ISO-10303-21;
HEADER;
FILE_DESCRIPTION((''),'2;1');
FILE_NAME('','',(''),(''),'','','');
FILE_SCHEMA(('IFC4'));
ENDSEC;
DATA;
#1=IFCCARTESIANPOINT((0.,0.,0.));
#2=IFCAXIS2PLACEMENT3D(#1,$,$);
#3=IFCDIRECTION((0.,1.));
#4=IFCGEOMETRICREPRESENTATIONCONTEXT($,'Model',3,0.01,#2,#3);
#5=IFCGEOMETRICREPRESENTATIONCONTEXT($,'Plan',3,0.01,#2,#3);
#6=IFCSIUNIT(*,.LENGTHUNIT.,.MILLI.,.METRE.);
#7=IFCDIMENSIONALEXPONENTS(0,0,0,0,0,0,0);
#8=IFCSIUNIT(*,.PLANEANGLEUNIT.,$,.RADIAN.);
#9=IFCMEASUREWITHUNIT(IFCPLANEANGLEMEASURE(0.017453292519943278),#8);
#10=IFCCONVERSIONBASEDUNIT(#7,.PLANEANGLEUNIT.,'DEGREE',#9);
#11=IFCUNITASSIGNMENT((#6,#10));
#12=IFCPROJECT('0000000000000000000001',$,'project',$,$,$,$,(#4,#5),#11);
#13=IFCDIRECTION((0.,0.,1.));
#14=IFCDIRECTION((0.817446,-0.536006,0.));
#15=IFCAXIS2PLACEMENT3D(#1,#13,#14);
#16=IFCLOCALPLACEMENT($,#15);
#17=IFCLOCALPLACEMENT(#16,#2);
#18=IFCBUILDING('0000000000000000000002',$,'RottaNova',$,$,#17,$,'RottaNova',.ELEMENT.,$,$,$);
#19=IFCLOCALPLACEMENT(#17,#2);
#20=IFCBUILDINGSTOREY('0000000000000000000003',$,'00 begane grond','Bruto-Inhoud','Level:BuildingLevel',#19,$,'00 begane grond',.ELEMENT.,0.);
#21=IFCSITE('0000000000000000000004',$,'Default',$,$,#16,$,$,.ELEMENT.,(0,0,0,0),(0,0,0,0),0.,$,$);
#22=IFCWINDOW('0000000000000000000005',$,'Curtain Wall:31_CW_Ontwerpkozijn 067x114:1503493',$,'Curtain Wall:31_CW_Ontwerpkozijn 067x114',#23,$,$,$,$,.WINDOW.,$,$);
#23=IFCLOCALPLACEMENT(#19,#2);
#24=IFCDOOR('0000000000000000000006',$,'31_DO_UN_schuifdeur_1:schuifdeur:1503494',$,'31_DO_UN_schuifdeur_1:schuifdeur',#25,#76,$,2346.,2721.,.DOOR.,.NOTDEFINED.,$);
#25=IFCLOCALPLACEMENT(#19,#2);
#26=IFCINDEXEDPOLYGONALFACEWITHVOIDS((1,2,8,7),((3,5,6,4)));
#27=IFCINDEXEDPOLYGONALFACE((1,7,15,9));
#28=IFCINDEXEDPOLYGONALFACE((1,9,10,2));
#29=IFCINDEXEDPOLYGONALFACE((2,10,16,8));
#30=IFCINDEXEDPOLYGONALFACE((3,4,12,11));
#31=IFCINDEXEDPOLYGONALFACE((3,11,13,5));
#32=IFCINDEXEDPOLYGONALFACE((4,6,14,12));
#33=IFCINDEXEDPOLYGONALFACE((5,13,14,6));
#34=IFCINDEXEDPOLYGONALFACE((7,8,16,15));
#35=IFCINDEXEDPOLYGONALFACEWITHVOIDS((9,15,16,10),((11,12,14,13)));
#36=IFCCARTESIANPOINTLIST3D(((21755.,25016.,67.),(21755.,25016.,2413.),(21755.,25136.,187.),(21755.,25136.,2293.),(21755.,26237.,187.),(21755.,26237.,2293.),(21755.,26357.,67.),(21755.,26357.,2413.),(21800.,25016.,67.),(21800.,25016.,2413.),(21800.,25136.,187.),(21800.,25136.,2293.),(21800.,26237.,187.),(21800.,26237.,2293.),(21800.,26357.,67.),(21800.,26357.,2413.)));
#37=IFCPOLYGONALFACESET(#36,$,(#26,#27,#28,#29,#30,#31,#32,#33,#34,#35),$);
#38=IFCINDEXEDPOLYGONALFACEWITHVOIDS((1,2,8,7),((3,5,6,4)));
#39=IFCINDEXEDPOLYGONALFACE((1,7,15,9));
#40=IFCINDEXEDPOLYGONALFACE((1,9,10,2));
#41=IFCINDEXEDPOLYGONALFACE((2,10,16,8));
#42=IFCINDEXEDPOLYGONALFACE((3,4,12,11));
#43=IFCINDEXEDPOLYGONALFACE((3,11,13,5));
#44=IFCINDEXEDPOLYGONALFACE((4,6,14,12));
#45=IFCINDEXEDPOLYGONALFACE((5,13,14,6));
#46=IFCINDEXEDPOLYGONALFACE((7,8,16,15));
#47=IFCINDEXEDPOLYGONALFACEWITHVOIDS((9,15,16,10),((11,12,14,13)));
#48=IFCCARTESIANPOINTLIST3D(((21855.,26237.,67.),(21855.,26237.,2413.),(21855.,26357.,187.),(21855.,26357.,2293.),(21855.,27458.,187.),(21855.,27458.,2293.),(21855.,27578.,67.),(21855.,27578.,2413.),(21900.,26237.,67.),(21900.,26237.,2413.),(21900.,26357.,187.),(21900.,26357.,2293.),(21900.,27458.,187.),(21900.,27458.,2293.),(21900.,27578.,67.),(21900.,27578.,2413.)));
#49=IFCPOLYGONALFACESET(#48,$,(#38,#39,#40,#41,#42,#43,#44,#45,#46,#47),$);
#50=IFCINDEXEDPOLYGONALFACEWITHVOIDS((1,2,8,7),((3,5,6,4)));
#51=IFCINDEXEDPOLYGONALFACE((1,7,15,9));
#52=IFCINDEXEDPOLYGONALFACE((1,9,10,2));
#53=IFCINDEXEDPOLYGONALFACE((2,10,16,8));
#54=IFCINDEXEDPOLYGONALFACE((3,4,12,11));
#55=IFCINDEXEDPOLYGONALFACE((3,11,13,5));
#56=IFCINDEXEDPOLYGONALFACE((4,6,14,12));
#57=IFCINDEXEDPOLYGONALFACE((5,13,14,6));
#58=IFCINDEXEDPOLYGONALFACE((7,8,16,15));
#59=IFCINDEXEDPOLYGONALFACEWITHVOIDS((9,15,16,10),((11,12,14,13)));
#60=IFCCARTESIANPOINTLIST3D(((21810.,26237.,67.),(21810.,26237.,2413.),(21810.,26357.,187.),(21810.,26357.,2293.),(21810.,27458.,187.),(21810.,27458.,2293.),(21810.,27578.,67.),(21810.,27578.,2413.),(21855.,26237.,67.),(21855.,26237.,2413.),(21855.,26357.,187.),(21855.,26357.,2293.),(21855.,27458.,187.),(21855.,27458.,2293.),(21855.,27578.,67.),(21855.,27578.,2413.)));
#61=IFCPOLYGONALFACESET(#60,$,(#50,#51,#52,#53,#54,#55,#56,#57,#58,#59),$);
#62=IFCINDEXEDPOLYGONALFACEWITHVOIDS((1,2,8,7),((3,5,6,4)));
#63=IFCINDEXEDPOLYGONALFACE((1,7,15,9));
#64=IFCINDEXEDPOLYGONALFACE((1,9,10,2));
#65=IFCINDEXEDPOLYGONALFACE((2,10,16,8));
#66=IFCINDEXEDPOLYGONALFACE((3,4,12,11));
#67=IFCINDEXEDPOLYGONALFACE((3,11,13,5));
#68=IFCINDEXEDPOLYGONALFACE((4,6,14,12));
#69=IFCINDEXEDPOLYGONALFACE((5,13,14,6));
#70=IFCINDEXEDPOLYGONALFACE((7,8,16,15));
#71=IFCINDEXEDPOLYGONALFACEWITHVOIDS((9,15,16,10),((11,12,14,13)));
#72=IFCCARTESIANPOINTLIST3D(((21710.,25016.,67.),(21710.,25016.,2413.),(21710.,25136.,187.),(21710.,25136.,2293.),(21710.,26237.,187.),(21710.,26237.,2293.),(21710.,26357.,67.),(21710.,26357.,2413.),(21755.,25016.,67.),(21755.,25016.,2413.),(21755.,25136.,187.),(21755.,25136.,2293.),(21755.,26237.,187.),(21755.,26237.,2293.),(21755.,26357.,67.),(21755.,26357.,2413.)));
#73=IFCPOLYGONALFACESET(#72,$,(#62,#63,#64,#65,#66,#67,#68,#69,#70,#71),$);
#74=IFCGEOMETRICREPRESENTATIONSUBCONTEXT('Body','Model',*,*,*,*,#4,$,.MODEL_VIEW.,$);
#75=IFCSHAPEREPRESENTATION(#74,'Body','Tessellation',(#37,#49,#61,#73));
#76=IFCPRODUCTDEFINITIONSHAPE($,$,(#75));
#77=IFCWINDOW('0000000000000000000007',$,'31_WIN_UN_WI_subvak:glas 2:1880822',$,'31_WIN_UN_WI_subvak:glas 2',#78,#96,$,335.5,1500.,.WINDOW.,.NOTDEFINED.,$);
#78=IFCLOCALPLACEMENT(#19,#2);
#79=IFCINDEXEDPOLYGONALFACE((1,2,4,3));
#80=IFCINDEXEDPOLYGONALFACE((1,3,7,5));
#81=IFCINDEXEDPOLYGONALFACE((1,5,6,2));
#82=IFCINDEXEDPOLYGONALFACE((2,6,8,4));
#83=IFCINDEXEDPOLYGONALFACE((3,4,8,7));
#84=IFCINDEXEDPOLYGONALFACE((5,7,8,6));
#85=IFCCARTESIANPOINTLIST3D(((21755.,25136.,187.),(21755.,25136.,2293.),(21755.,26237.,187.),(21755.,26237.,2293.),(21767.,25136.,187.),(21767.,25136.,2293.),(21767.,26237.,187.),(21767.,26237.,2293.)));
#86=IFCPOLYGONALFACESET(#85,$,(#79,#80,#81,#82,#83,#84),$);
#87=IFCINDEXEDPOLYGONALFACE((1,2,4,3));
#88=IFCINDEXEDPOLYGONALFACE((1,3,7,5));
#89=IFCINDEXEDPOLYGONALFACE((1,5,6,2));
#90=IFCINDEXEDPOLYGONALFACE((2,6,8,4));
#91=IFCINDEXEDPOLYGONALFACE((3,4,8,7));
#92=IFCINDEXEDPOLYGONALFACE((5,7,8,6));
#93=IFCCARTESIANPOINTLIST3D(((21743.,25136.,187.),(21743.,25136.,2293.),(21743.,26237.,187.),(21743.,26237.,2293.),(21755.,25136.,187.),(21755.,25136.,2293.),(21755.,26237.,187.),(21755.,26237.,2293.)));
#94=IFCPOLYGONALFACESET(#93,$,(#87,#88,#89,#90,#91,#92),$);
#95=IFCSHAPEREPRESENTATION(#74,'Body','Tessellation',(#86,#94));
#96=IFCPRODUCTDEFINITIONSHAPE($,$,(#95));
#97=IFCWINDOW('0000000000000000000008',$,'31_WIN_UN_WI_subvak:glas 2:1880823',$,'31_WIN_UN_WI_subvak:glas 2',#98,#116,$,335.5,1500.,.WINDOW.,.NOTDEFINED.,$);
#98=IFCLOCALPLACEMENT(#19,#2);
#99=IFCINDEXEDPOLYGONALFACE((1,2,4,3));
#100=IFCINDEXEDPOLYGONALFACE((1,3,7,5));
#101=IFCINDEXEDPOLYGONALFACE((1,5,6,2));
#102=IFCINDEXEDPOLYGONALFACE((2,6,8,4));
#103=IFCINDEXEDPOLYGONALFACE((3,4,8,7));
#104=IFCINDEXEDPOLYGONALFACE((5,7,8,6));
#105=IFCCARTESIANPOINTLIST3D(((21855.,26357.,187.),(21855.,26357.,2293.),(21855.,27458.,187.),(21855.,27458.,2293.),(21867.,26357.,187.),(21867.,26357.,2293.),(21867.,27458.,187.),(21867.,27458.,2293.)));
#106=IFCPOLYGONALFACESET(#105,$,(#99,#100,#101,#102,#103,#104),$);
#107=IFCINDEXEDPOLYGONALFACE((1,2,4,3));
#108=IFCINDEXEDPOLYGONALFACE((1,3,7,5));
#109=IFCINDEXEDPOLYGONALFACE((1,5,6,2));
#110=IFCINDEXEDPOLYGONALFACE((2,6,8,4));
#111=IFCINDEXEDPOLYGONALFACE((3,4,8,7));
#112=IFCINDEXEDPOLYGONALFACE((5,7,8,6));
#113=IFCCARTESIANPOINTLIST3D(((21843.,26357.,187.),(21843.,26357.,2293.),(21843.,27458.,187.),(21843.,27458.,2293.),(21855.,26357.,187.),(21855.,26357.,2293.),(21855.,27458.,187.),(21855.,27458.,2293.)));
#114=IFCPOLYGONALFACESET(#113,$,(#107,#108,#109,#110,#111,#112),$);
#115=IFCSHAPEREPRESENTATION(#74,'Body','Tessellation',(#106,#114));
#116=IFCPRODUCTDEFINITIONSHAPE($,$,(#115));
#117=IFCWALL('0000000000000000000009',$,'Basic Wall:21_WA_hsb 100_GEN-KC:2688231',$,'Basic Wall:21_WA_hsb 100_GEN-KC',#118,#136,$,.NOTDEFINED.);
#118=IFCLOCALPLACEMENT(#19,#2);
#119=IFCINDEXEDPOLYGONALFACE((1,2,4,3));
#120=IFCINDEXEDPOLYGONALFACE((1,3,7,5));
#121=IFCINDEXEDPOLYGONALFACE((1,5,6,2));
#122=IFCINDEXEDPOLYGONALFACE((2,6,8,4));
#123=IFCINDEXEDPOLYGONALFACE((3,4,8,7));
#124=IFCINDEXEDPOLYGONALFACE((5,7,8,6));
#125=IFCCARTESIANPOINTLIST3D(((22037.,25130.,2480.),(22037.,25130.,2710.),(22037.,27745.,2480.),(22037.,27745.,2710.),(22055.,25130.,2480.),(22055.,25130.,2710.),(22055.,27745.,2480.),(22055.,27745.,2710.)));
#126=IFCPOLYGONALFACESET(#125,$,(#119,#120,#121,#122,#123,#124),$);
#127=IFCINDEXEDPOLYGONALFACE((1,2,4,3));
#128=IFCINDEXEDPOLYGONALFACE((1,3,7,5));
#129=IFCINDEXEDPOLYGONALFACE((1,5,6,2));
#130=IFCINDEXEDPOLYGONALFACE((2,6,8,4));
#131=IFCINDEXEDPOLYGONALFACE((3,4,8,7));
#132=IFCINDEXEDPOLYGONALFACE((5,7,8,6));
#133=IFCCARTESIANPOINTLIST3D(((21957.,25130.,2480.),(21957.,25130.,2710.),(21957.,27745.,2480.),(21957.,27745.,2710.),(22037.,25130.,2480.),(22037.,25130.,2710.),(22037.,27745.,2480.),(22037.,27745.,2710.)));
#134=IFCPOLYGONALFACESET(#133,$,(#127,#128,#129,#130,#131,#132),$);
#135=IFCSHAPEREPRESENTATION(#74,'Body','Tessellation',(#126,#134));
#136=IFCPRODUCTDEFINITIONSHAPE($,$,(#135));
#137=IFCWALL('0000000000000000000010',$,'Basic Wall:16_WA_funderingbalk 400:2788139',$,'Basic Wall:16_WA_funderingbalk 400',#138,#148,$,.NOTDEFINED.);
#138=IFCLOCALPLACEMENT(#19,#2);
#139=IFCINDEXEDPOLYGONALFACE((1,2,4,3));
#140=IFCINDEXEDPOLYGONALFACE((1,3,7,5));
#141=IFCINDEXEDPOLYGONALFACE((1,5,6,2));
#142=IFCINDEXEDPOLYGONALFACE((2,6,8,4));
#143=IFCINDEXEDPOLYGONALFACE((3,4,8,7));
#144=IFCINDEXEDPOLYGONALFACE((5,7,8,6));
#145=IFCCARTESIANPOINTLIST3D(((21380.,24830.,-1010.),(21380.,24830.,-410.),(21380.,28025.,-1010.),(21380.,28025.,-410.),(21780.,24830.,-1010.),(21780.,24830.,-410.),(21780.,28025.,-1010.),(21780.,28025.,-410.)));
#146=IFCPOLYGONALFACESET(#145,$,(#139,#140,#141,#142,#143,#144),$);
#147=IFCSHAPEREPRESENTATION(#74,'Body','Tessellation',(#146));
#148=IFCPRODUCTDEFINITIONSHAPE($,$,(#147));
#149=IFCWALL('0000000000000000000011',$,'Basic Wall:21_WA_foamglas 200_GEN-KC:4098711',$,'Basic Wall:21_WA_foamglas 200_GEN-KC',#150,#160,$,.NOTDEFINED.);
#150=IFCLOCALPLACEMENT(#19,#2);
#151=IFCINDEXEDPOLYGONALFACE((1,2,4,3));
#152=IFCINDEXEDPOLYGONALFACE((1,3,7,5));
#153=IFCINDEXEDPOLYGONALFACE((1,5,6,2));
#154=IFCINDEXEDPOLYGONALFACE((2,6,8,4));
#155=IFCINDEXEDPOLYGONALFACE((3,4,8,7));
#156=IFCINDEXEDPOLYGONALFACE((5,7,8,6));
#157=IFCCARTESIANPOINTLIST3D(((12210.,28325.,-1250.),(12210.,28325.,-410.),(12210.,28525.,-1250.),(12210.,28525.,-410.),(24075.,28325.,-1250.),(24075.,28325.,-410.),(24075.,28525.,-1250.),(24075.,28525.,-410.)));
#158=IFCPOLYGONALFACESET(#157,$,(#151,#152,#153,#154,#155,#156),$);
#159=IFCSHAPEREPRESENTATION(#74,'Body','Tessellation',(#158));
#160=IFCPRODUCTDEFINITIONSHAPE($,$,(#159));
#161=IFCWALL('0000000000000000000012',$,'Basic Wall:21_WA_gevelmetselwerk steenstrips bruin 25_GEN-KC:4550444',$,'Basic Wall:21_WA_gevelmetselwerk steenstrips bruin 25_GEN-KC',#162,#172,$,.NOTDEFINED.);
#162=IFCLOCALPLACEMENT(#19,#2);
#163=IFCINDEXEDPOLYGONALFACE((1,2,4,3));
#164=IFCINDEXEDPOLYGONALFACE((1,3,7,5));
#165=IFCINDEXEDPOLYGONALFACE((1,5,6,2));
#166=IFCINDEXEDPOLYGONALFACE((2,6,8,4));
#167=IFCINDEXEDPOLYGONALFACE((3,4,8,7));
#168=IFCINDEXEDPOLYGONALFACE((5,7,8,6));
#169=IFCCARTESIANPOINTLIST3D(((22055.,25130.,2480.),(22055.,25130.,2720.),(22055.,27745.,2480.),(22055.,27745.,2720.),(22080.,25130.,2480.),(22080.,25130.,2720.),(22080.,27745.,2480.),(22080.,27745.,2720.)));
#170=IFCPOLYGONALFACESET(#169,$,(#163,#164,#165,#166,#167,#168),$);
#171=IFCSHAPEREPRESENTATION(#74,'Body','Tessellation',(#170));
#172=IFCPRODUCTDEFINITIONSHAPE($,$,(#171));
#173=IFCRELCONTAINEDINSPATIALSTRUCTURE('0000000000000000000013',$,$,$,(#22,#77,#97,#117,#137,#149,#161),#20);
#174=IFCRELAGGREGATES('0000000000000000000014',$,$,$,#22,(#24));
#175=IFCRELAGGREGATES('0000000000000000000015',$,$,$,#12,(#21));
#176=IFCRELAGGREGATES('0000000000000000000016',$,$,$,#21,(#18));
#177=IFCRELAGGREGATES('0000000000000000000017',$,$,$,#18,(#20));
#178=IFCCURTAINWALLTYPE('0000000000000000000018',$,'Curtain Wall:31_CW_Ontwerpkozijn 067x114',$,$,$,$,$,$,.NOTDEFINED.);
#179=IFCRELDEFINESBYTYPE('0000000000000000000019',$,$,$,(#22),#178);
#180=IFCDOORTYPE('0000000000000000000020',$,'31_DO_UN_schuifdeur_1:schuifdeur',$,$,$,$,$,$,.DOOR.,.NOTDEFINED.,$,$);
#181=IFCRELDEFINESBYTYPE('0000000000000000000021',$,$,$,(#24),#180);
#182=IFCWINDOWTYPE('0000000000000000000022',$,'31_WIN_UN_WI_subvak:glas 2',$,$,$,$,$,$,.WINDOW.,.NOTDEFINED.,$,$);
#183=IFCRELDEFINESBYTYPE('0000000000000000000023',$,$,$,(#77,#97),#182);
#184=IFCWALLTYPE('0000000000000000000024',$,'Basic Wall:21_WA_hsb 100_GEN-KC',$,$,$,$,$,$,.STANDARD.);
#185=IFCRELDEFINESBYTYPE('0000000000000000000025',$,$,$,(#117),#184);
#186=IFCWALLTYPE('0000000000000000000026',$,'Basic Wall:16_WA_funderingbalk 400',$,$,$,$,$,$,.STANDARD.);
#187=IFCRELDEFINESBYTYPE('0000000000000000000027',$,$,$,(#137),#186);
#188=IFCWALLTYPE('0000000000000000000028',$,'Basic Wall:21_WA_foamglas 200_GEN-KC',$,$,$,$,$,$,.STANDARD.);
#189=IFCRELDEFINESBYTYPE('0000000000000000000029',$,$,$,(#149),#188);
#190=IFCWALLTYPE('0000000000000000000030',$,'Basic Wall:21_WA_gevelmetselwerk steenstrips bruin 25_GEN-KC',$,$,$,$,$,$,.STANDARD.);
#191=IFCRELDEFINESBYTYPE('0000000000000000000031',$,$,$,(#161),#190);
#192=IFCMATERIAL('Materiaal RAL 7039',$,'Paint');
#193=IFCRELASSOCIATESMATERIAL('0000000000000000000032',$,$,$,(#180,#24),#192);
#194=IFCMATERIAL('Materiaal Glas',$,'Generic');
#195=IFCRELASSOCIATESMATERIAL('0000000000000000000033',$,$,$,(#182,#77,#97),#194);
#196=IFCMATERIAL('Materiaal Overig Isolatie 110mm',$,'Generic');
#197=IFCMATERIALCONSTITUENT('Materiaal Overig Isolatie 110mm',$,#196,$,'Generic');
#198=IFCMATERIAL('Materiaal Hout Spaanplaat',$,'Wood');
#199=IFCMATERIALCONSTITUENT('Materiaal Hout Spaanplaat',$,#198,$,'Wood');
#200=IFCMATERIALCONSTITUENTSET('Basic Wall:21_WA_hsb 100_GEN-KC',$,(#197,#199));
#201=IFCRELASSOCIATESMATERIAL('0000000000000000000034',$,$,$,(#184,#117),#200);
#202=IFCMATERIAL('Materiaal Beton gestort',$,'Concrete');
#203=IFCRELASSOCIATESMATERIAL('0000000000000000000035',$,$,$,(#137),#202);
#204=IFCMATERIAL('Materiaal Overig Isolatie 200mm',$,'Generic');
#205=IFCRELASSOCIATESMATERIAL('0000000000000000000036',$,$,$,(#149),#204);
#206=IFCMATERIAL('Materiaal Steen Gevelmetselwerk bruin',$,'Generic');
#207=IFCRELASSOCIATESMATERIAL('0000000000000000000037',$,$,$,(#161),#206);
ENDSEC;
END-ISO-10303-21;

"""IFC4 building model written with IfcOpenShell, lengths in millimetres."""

from ifc_helpers import new_model, entity, si_unit, converted_unit, direction, frame, origin, place, context, subcontext, project, spatial, indexed_curve, outline, extrude, source, transform, mapped, material, constituent, constituent_set, type_object, type_shapes, element, aggregate, save


model = new_model("IFC4")

# Units and contexts
model_context = context("Model", 3, precision=0.01, world=origin(), true_north=direction((0.0, 1.0)))
plan_context = context("Plan", 3, precision=0.01, world=origin(), true_north=direction((0.0, 1.0)))
body_context = subcontext(model_context, "Body", "Model", "MODEL_VIEW")
ifc_project = project(units=[si_unit("LENGTHUNIT", "METRE", prefix="MILLI"), converted_unit("PLANEANGLEUNIT", "DEGREE", entity("IfcPlaneAngleMeasure", 0.017453292519943278), si_unit("PLANEANGLEUNIT", "RADIAN"), dimensions=[0, 0, 0, 0, 0, 0, 0])], contexts=[model_context, plan_context])

# Site, building, storey
site_placement = place(None, frame((0.0, 0.0, 0.0), z_axis=(0.0, 0.0, 1.0), x_axis=(0.817446, -0.536006, 0.0)))
site = spatial("IfcSite", under=ifc_project, at=site_placement, Name="Default", CompositionType="ELEMENT", RefLatitude=(0, 0, 0, 0), RefLongitude=(0, 0, 0, 0), RefElevation=0.0)
building_placement = place(site_placement, origin())
building = spatial("IfcBuilding", under=site, at=building_placement, Name="RottaNova", LongName="RottaNova", CompositionType="ELEMENT")
storey_placement = place(building_placement, origin())
storey = spatial("IfcBuildingStorey", under=building, at=storey_placement, Name="00 begane grond", Description="Bruto-Inhoud", ObjectType="Level:BuildingLevel", LongName="00 begane grond", CompositionType="ELEMENT", Elevation=0.0)

# Window
curtain_wall_type = type_object("IfcCurtainWallType", Name="Curtain Wall:31_CW_Ontwerpkozijn 067x114", PredefinedType="NOTDEFINED")
window_1_placement = place(storey_placement, origin())
window_1 = element("IfcWindow", 1, at=window_1_placement, inside=storey, type_object=curtain_wall_type, Name="Curtain Wall:31_CW_Ontwerpkozijn 067x114:1503493", ObjectType="Curtain Wall:31_CW_Ontwerpkozijn 067x114", PredefinedType="WINDOW")
ifc_material_1 = material(Name="Materiaal RAL 7039", Category="Paint")

# Shared definitions
ifc_material_2 = material(Name="Materiaal Glas", Category="Generic")

# Shared definitions
ifc_material_3 = material(Name="Materiaal Steen Gevelmetselwerk bruin", Category="Generic")

# Door
door_type = type_object("IfcDoorType", Name="31_DO_UN_schuifdeur_1:schuifdeur", OperationType="NOTDEFINED", PredefinedType="DOOR", material=ifc_material_1)
shared_shape_1 = source(origin(), body_context, "Body", "SweptSolid", [
    extrude(outline(indexed_curve([(-670.5, -1173.0), (670.5, -1173.0), (670.5, 1173.0), (-670.5, 1173.0), (-670.5, -1173.0)], self_intersect=False), holes=[indexed_curve([(-550.5, -1053.0), (-550.5, 1053.0), (550.5, 1053.0), (550.5, -1053.0), (-550.5, -1053.0)], self_intersect=False)]), frame((610.5, 45.0, 1173.0), z_axis=(0.0, 1.0, 0.0), x_axis=(1.0, 0.0, 0.0)), (0.0, 0.0, 1.0), 45.0),
    extrude(outline(indexed_curve([(-670.5, -1173.0), (670.5, -1173.0), (670.5, 1173.0), (-670.5, 1173.0), (-670.5, -1173.0)], self_intersect=False), holes=[indexed_curve([(-550.5, -1053.0), (-550.5, 1053.0), (550.5, 1053.0), (550.5, -1053.0), (-550.5, -1053.0)], self_intersect=False)]), frame((-610.5, 145.0, 1173.0), z_axis=(0.0, 1.0, 0.0), x_axis=(1.0, 0.0, 0.0)), (0.0, 0.0, 1.0), 45.0),
    extrude(outline(indexed_curve([(-670.5, -1173.0), (670.5, -1173.0), (670.5, 1173.0), (-670.5, 1173.0), (-670.5, -1173.0)], self_intersect=False), holes=[indexed_curve([(-550.5, -1053.0), (-550.5, 1053.0), (550.5, 1053.0), (550.5, -1053.0), (-550.5, -1053.0)], self_intersect=False)]), frame((-610.5, 100.0, 1173.0), z_axis=(0.0, 1.0, 0.0), x_axis=(1.0, 0.0, 0.0)), (0.0, 0.0, 1.0), 45.0),
    extrude(outline(indexed_curve([(-670.5, -1173.0), (670.5, -1173.0), (670.5, 1173.0), (-670.5, 1173.0), (-670.5, -1173.0)], self_intersect=False), holes=[indexed_curve([(-550.5, -1053.0), (-550.5, 1053.0), (550.5, 1053.0), (550.5, -1053.0), (-550.5, -1053.0)], self_intersect=False)]), frame((610.5, 0.0, 1173.0), z_axis=(0.0, 1.0, 0.0), x_axis=(1.0, 0.0, 0.0)), (0.0, 0.0, 1.0), 45.0),
])
type_shapes(door_type, [shared_shape_1])
door_placement = place(window_1_placement, frame((21710.0, 26297.0, 67.0), z_axis=(0.0, 0.0, 1.0), x_axis=(0.0, -1.0, 0.0)))
door = element("IfcDoor", 2, at=door_placement, type_object=door_type, material=ifc_material_1, Name="31_DO_UN_schuifdeur_1:schuifdeur:1503494", ObjectType="31_DO_UN_schuifdeur_1:schuifdeur", OperationType="NOTDEFINED", OverallHeight=2346.0, OverallWidth=2721.0, PredefinedType="DOOR", context=body_context, shape_type="MappedRepresentation", body=[
    mapped(shared_shape_1, transform((0.0, 0.0, 0.0), scale=1.0)),
])
aggregate(window_1, [door])

# Windows
window_type = type_object("IfcWindowType", Name="31_WIN_UN_WI_subvak:glas 2", PartitioningType="NOTDEFINED", PredefinedType="WINDOW", material=ifc_material_2)
shared_shape_2 = source(origin(), body_context, "Body", "SweptSolid", [
    extrude(outline(indexed_curve([(-6.0, -550.5), (6.0, -550.5), (6.0, 550.5), (-6.0, 550.5), (-6.0, -550.5)], self_intersect=False)), frame((0.0, 6.0, 0.0), z_axis=(0.0, 0.0, 1.0), x_axis=(0.0, -1.0, 0.0)), (0.0, 0.0, 1.0), 2106.0),
    extrude(outline(indexed_curve([(-6.0, -550.5), (6.0, -550.5), (6.0, 550.5), (-6.0, 550.5), (-6.0, -550.5)], self_intersect=False)), frame((0.0, -6.0, 0.0), z_axis=(0.0, 0.0, 1.0), x_axis=(0.0, -1.0, 0.0)), (0.0, 0.0, 1.0), 2106.0),
])
type_shapes(window_type, [shared_shape_2])
for number, where, z_axis, x_axis, name in (
    (3, (21755.0, 25686.5, 187.0), (0.0, 0.0, 1.0), (0.0, -1.0, 0.0), "31_WIN_UN_WI_subvak:glas 2:1880822"),
    (4, (21855.0, 26907.5, 187.0), (0.0, 0.0, 1.0), (0.0, -1.0, 0.0), "31_WIN_UN_WI_subvak:glas 2:1880823"),
):
    element("IfcWindow", number, at=place(storey_placement, frame(where, z_axis=z_axis, x_axis=x_axis)), inside=storey, type_object=window_type, material=ifc_material_2, Name=name, ObjectType="31_WIN_UN_WI_subvak:glas 2", OverallHeight=335.5, OverallWidth=1500.0, PartitioningType="NOTDEFINED", PredefinedType="WINDOW", context=body_context, shape_type="MappedRepresentation", body=[
        mapped(shared_shape_2, transform((0.0, 0.0, 0.0), scale=1.0)),
    ])

# Walls
ifc_material_4 = material(Name="Materiaal Overig Isolatie 110mm", Category="Generic")
ifc_constituent_1 = constituent(ifc_material_4, Name="Materiaal Overig Isolatie 110mm", Category="Generic")
ifc_material_5 = material(Name="Materiaal Hout Spaanplaat", Category="Wood")
ifc_constituent_2 = constituent(ifc_material_5, Name="Materiaal Hout Spaanplaat", Category="Wood")
ifc_constituent_set = constituent_set(constituents=[ifc_constituent_1, ifc_constituent_2], Name="Basic Wall:21_WA_hsb 100_GEN-KC")
wall_type_1 = type_object("IfcWallType", Name="Basic Wall:21_WA_hsb 100_GEN-KC", PredefinedType="STANDARD", material=ifc_constituent_set)
wall_1_placement = place(storey_placement, frame((22006.0, 25130.0, 2480.0), z_axis=(0.0, 0.0, 1.0), x_axis=(0.0, 1.0, 0.0)))
element("IfcWall", 5, at=wall_1_placement, inside=storey, type_object=wall_type_1, material=ifc_constituent_set, Name="Basic Wall:21_WA_hsb 100_GEN-KC:2688231", ObjectType="Basic Wall:21_WA_hsb 100_GEN-KC", PredefinedType="NOTDEFINED", context=body_context, shape_type="SweptSolid", body=[
    extrude(outline(indexed_curve([(-9.0, -1307.5), (9.0, -1307.5), (9.0, 1307.5), (-9.0, 1307.5), (-9.0, -1307.5)], self_intersect=False)), frame((1307.5, -40.0, 0.0), z_axis=(0.0, 0.0, 1.0), x_axis=(0.0, 1.0, 0.0)), (0.0, 0.0, 1.0), 230.0),
    extrude(outline(indexed_curve([(-40.0, -1307.5), (40.0, -1307.5), (40.0, 1307.5), (-40.0, 1307.5), (-40.0, -1307.5)], self_intersect=False)), frame((1307.5, 9.0, 0.0), z_axis=(0.0, 0.0, 1.0), x_axis=(0.0, -1.0, 0.0)), (0.0, 0.0, 1.0), 230.0),
])
ifc_material_6 = material(Name="Materiaal Beton gestort", Category="Concrete")
wall_type_2 = type_object("IfcWallType", Name="Basic Wall:16_WA_funderingbalk 400", PredefinedType="STANDARD")
wall_2_placement = place(storey_placement, frame((21580.0, 28025.0, -1010.0), z_axis=(0.0, 0.0, 1.0), x_axis=(0.0, -1.0, 0.0)))
element("IfcWall", 6, at=wall_2_placement, inside=storey, type_object=wall_type_2, material=ifc_material_6, Name="Basic Wall:16_WA_funderingbalk 400:2788139", ObjectType="Basic Wall:16_WA_funderingbalk 400", PredefinedType="NOTDEFINED", context=body_context, shape_type="SweptSolid", body=[
    extrude(outline(indexed_curve([(3195.0, 200.0), (0.0, 200.0), (0.0, -200.0), (3195.0, -200.0), (3195.0, 200.0)], self_intersect=False)), origin(), (0.0, 0.0, 1.0), 600.0),
])
ifc_material_7 = material(Name="Materiaal Overig Isolatie 200mm", Category="Generic")
wall_type_3 = type_object("IfcWallType", Name="Basic Wall:21_WA_foamglas 200_GEN-KC", PredefinedType="STANDARD")
wall_3_placement = place(storey_placement, frame((24075.0, 28425.0, -1250.0), z_axis=(0.0, 0.0, 1.0), x_axis=(-1.0, 0.0, 0.0)))
element("IfcWall", 7, at=wall_3_placement, inside=storey, type_object=wall_type_3, material=ifc_material_7, Name="Basic Wall:21_WA_foamglas 200_GEN-KC:4098711", ObjectType="Basic Wall:21_WA_foamglas 200_GEN-KC", PredefinedType="NOTDEFINED", context=body_context, shape_type="SweptSolid", body=[
    extrude(outline(indexed_curve([(11865.0, 100.0), (0.0, 100.0), (0.0, -100.0), (11865.0, -100.0), (11865.0, 100.0)], self_intersect=False)), origin(), (0.0, 0.0, 1.0), 840.0),
])
wall_type_4 = type_object("IfcWallType", Name="Basic Wall:21_WA_gevelmetselwerk steenstrips bruin 25_GEN-KC", PredefinedType="STANDARD")
wall_4_placement = place(storey_placement, frame((22067.5, 27745.0, 2480.0), z_axis=(0.0, 0.0, 1.0), x_axis=(0.0, -1.0, 0.0)))
element("IfcWall", 8, at=wall_4_placement, inside=storey, type_object=wall_type_4, material=ifc_material_3, Name="Basic Wall:21_WA_gevelmetselwerk steenstrips bruin 25_GEN-KC:4550444", ObjectType="Basic Wall:21_WA_gevelmetselwerk steenstrips bruin 25_GEN-KC", PredefinedType="NOTDEFINED", context=body_context, shape_type="SweptSolid", body=[
    extrude(outline(indexed_curve([(2615.0, 12.5), (0.0, 12.5), (0.0, -12.5), (2615.0, -12.5), (2615.0, 12.5)], self_intersect=False)), origin(), (0.0, 0.0, 1.0), 240.0),
])

save(model, "model.ifc")
